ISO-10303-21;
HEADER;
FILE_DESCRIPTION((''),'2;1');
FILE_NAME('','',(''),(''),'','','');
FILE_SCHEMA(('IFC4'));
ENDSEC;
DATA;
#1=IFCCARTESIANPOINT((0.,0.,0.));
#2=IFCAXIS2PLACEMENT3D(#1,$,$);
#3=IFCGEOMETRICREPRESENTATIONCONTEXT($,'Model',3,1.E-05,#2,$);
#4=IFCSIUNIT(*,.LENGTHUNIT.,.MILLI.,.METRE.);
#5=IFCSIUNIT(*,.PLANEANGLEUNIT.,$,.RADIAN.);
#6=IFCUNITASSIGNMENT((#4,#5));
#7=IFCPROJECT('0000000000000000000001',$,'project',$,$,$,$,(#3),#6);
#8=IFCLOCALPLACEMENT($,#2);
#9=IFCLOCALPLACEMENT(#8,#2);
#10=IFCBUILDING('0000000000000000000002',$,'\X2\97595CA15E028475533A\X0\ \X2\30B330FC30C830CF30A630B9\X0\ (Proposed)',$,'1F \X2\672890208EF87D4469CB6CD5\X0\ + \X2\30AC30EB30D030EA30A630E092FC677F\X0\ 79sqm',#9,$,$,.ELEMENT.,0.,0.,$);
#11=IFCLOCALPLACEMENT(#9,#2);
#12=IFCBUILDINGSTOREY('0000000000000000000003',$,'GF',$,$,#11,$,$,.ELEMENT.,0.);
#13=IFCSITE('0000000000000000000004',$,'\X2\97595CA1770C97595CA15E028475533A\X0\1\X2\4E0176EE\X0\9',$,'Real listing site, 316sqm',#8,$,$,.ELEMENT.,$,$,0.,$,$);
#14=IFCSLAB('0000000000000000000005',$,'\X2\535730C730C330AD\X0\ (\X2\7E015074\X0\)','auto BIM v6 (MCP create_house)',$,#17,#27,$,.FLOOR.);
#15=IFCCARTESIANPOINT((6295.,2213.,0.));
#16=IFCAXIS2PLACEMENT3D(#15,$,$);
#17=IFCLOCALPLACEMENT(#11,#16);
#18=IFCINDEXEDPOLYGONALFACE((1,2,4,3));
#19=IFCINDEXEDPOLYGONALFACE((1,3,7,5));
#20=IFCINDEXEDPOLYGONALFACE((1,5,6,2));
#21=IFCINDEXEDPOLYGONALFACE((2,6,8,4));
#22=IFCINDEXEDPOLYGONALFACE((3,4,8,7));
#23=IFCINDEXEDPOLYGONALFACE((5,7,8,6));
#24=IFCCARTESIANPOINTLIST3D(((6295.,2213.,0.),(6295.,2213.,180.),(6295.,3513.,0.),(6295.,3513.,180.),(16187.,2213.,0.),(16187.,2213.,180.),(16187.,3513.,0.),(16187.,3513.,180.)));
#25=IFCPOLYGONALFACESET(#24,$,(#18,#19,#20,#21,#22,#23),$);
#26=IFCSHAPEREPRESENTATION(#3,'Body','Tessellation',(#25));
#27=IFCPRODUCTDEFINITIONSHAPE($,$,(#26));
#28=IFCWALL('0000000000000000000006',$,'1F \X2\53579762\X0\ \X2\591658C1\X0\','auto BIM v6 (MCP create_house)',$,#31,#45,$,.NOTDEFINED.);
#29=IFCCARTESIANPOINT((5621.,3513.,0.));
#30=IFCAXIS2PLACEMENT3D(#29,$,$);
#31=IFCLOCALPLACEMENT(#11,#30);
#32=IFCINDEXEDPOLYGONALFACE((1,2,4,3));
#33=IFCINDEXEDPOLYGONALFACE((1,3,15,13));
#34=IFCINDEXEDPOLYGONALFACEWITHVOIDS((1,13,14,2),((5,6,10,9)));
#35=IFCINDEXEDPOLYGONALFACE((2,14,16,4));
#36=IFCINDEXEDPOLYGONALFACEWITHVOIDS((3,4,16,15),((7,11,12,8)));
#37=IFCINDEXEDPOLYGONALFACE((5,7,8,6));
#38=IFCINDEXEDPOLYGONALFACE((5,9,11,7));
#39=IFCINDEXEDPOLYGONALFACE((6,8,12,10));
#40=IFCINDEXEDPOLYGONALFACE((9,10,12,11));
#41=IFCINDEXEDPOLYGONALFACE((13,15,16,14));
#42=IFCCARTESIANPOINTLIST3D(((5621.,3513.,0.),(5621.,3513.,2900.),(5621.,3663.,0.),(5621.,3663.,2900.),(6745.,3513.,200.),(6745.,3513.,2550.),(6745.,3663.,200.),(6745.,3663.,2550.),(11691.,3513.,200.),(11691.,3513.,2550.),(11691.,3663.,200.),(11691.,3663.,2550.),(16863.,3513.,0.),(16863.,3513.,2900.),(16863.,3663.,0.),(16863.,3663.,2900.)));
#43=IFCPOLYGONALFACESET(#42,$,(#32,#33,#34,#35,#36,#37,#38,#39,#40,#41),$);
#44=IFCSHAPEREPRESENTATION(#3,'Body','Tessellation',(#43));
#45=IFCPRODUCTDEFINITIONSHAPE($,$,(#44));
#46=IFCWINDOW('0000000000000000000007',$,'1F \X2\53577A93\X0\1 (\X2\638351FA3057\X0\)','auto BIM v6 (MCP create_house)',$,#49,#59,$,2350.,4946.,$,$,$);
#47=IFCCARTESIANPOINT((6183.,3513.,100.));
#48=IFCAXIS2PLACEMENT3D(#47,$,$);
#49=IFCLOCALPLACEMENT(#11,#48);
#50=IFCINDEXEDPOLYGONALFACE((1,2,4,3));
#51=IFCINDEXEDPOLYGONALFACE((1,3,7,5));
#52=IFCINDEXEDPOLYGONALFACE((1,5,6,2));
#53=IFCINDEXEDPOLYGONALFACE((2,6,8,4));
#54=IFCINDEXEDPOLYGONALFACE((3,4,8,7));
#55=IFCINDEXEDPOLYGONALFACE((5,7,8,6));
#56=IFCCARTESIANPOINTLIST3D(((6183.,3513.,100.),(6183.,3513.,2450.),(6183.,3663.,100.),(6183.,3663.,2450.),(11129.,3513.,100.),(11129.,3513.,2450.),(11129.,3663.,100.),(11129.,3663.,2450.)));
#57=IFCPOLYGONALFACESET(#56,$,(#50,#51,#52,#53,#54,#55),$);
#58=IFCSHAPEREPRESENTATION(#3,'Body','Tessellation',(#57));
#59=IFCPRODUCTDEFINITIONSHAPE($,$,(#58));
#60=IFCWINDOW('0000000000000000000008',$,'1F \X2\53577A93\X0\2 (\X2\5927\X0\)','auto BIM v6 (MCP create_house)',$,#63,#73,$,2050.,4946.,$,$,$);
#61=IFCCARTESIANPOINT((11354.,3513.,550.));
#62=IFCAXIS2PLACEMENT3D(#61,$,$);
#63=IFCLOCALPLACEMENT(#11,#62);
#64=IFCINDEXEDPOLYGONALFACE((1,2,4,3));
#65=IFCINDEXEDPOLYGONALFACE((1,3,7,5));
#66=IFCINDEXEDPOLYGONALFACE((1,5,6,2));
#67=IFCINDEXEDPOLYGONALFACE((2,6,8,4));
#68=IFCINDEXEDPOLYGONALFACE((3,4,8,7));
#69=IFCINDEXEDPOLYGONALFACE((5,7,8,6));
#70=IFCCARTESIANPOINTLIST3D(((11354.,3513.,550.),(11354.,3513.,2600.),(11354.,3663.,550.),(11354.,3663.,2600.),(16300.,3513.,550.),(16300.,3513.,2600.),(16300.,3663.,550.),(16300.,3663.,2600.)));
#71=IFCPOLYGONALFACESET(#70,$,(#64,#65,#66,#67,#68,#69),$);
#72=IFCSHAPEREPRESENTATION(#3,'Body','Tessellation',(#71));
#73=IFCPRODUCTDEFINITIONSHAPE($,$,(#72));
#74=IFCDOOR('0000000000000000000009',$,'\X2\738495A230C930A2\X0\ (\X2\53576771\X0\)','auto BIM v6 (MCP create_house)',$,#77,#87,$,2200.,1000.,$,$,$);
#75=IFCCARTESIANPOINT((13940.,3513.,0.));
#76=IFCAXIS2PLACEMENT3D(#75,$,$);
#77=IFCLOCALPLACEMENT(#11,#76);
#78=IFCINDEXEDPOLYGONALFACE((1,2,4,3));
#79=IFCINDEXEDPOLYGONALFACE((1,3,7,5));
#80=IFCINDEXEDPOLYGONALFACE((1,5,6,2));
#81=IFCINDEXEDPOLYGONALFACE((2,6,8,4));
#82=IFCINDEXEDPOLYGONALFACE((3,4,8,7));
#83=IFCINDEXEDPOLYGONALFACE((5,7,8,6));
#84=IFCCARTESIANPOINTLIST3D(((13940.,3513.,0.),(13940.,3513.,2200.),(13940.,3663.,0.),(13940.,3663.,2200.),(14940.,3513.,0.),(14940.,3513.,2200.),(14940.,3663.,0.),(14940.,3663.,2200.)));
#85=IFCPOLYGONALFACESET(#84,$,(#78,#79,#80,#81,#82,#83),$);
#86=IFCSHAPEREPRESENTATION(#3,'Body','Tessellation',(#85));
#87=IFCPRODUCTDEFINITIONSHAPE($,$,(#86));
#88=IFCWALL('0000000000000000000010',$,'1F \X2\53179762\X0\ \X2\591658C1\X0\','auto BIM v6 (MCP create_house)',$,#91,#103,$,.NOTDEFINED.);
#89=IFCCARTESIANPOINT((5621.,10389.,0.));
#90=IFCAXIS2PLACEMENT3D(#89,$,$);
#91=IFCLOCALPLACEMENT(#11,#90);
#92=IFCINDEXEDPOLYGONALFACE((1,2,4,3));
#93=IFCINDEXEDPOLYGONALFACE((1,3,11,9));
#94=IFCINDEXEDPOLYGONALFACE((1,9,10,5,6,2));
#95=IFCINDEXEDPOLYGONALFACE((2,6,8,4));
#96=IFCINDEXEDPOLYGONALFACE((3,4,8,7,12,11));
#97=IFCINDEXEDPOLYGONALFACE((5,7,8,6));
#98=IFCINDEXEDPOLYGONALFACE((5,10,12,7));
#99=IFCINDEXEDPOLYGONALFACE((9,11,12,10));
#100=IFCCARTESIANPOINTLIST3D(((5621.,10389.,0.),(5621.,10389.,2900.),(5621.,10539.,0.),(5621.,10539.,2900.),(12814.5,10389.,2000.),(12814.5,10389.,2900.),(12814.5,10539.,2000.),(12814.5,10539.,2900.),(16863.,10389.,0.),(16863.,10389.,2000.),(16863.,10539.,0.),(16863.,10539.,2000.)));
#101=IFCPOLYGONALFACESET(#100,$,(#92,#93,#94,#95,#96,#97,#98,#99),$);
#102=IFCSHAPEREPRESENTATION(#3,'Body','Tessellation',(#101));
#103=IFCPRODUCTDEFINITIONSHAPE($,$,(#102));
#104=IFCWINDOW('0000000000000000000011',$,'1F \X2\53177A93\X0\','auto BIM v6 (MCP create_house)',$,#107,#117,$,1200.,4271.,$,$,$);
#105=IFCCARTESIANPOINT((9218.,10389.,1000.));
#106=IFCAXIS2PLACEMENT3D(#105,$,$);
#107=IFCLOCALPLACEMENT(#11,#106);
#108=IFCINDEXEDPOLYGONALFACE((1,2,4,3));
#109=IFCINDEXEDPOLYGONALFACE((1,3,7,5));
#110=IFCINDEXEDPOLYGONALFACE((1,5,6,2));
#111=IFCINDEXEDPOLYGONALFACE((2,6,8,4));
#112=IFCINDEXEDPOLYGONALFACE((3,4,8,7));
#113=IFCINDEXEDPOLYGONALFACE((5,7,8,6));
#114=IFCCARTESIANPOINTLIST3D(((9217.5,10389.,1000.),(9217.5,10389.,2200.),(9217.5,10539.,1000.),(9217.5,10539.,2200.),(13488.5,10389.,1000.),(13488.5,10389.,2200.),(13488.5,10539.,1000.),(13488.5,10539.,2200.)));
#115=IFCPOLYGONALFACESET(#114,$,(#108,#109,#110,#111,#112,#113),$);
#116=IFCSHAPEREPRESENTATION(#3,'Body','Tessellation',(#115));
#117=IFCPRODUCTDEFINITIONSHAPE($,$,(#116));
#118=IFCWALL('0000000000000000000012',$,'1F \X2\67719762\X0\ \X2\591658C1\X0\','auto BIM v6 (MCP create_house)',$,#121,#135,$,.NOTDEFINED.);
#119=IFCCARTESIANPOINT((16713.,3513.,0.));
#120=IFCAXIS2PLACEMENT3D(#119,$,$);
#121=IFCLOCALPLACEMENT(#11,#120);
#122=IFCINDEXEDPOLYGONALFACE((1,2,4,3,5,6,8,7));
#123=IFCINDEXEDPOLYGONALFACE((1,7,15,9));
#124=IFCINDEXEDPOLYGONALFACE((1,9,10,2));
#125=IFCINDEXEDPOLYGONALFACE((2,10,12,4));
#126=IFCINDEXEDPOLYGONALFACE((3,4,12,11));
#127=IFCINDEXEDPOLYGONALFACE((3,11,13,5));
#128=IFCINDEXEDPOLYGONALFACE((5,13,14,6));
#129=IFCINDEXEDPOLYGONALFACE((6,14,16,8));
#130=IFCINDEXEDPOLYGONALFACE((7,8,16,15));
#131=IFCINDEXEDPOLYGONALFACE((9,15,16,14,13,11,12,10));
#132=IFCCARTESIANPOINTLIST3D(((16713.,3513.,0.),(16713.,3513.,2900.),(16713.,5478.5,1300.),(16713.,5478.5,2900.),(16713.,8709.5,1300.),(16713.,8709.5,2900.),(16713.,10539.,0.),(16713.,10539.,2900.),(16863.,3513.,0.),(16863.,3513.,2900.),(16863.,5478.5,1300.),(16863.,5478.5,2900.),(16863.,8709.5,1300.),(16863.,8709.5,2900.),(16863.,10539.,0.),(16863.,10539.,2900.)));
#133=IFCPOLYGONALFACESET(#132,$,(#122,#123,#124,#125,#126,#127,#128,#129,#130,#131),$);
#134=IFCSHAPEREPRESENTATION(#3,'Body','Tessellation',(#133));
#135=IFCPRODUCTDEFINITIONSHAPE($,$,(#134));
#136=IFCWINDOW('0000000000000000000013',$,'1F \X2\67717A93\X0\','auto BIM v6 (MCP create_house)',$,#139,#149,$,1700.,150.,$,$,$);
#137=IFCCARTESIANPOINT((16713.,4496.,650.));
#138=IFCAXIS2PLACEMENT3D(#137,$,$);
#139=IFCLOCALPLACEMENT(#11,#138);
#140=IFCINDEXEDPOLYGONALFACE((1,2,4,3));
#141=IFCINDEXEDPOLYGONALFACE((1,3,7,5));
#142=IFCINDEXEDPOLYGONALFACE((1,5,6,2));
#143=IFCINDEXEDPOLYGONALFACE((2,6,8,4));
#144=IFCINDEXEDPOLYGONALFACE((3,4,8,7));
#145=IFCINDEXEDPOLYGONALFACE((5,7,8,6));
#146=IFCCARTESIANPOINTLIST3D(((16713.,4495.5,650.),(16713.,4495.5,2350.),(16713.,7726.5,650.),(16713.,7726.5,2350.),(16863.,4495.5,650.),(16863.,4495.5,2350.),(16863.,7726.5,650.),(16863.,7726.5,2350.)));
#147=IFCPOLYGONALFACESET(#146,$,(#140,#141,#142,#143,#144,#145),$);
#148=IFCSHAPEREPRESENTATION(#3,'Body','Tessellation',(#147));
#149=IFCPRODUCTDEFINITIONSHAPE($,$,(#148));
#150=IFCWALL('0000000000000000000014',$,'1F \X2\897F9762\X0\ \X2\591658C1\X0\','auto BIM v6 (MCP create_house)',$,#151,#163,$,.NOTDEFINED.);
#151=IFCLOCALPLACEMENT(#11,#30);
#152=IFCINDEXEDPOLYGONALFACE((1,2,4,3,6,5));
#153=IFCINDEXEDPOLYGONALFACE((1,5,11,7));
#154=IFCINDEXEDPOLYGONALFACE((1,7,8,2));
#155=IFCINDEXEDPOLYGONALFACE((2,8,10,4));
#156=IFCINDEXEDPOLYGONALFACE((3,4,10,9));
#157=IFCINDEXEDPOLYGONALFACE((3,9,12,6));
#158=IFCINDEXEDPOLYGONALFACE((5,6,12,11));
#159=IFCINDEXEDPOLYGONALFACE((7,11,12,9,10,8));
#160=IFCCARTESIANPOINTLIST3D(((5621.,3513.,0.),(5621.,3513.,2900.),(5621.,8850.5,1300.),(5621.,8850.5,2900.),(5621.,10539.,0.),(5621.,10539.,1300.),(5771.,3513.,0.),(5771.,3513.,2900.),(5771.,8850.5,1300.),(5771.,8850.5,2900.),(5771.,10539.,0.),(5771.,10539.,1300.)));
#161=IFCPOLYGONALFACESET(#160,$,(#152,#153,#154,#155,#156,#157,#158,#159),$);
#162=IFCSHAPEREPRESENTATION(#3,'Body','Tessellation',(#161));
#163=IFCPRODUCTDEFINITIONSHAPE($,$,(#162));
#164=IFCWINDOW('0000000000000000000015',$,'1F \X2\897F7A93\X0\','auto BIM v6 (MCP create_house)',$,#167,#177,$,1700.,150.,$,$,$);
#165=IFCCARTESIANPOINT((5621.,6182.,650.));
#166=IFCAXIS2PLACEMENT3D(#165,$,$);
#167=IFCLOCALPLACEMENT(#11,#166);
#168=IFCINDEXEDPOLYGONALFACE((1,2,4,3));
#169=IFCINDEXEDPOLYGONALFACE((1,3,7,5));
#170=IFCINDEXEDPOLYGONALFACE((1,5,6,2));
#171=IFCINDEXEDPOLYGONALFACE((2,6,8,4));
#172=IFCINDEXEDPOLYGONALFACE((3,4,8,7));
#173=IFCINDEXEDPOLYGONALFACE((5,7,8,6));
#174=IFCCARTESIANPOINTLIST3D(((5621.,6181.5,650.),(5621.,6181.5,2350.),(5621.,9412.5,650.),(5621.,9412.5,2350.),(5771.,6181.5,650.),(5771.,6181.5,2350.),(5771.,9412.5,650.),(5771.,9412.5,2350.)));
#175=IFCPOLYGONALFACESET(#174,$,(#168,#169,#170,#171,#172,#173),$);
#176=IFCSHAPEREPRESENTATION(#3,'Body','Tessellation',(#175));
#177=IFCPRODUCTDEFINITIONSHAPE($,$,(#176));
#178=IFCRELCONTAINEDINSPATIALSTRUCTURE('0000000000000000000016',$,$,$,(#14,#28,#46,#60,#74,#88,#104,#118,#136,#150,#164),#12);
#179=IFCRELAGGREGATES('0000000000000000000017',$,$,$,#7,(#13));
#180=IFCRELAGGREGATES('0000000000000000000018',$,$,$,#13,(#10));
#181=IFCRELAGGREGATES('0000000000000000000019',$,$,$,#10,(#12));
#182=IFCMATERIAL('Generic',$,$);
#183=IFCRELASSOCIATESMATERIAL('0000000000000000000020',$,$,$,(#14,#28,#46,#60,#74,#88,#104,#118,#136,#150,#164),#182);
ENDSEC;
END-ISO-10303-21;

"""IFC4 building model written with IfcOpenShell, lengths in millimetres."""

from ifc_helpers import new_model, si_unit, frame, frame_2d, origin, place, context, project, spatial, rectangle, extrude, material, element, fill, save


model = new_model("IFC4")

# Units and contexts
model_context = context("Model", 3, precision=1e-05, world=origin())
ifc_project = project(units=[si_unit("LENGTHUNIT", "METRE", prefix="MILLI"), si_unit("PLANEANGLEUNIT", "RADIAN")], contexts=[model_context])

# Site, building, storey
site_placement = place(None, origin())
site = spatial("IfcSite", under=ifc_project, at=site_placement, Name="静岡県静岡市葵区1丁目9", ObjectType="Real listing site, 316sqm", CompositionType="ELEMENT", RefElevation=0.0)
building_placement = place(site_placement, origin())
building = spatial("IfcBuilding", under=site, at=building_placement, Name="静岡市葵区 コートハウス (Proposed)", ObjectType="1F 木造軸組構法 + ガルバリウム鋼板 79sqm", CompositionType="ELEMENT", ElevationOfRefHeight=0.0, ElevationOfTerrain=0.0)
storey_placement = place(building_placement, origin())
storey = spatial("IfcBuildingStorey", under=building, at=storey_placement, Name="GF", CompositionType="ELEMENT", Elevation=0.0)

# Slab
ifc_material = material(Name="Generic")
slab_1_placement = place(storey_placement, frame((6295.0, 2213.0, 0.0)))
element("IfcSlab", 1, at=slab_1_placement, inside=storey, material=ifc_material, Name="南デッキ (縁側)", Description="auto BIM v6 (MCP create_house)", PredefinedType="FLOOR", context=model_context, shape_type="SweptSolid", body=[
    extrude(rectangle(XDim=9892.0, YDim=1300.0, at=frame_2d((4946.0, 650.0))), frame((6295.0, 2213.0, 0.0)), (0.0, 0.0, 1.0), 180.0),
])

# Wall, openings, windows, door
wall_1_placement = place(storey_placement, frame((5621.0, 3513.0, 0.0)))
wall_1 = element("IfcWall", 2, at=wall_1_placement, inside=storey, material=ifc_material, Name="1F 南面 外壁", Description="auto BIM v6 (MCP create_house)", PredefinedType="NOTDEFINED", context=model_context, shape_type="SweptSolid", body=[
    extrude(rectangle(XDim=11242.0, YDim=150.0, at=frame_2d((5621.0, 75.0))), frame((5621.0, 3513.0, 0.0)), (0.0, 0.0, 1.0), 2900.0),
])
opening_1_placement = place(storey_placement, frame((6183.0, 3513.0, 100.0)))
opening_1 = element("IfcOpeningElement", 3, at=opening_1_placement, cuts=wall_1, PredefinedType="NOTDEFINED", context=model_context, shape_type="SweptSolid", body=[
    extrude(rectangle(XDim=4946.0, YDim=150.0, at=frame_2d((2473.0, 75.0))), frame((6183.0, 3513.0, 100.0)), (0.0, 0.0, 1.0), 2350.0),
])
opening_2_placement = place(storey_placement, frame((11354.0, 3513.0, 550.0)))
opening_2 = element("IfcOpeningElement", 4, at=opening_2_placement, cuts=wall_1, PredefinedType="NOTDEFINED", context=model_context, shape_type="SweptSolid", body=[
    extrude(rectangle(XDim=4946.0, YDim=150.0, at=frame_2d((2473.0, 75.0))), frame((11354.0, 3513.0, 550.0)), (0.0, 0.0, 1.0), 2050.0),
])
opening_3_placement = place(storey_placement, frame((13940.0, 3513.0, 0.0)))
opening_3 = element("IfcOpeningElement", 5, at=opening_3_placement, cuts=wall_1, PredefinedType="NOTDEFINED", context=model_context, shape_type="SweptSolid", body=[
    extrude(rectangle(XDim=1000.0, YDim=150.0, at=frame_2d((500.0, 75.0))), frame((13940.0, 3513.0, 0.0)), (0.0, 0.0, 1.0), 2200.0),
])
window_1_placement = place(storey_placement, frame((6183.0, 3513.0, 100.0)))
window_1 = element("IfcWindow", 6, at=window_1_placement, inside=storey, material=ifc_material, Name="1F 南窓1 (掃出し)", Description="auto BIM v6 (MCP create_house)", OverallHeight=2350.0, OverallWidth=4946.0, context=model_context, shape_type="SweptSolid", body=[
    extrude(rectangle(XDim=4946.0, YDim=150.0, at=frame_2d((2473.0, 75.0))), frame((6183.0, 3513.0, 100.0)), (0.0, 0.0, 1.0), 2350.0),
])
fill(opening_1, window_1)
window_2_placement = place(storey_placement, frame((11354.0, 3513.0, 550.0)))
window_2 = element("IfcWindow", 7, at=window_2_placement, inside=storey, material=ifc_material, Name="1F 南窓2 (大)", Description="auto BIM v6 (MCP create_house)", OverallHeight=2050.0, OverallWidth=4946.0, context=model_context, shape_type="SweptSolid", body=[
    extrude(rectangle(XDim=4946.0, YDim=150.0, at=frame_2d((2473.0, 75.0))), frame((11354.0, 3513.0, 550.0)), (0.0, 0.0, 1.0), 2050.0),
])
fill(opening_2, window_2)
door_placement = place(storey_placement, frame((13940.0, 3513.0, 0.0)))
door = element("IfcDoor", 8, at=door_placement, inside=storey, material=ifc_material, Name="玄関ドア (南東)", Description="auto BIM v6 (MCP create_house)", OverallHeight=2200.0, OverallWidth=1000.0, context=model_context, shape_type="SweptSolid", body=[
    extrude(rectangle(XDim=1000.0, YDim=150.0, at=frame_2d((500.0, 75.0))), frame((13940.0, 3513.0, 0.0)), (0.0, 0.0, 1.0), 2200.0),
])
fill(opening_3, door)

# Walls, openings, windows
wall_2_placement = place(storey_placement, frame((5621.0, 10389.0, 0.0)))
wall_2 = element("IfcWall", 9, at=wall_2_placement, inside=storey, material=ifc_material, Name="1F 北面 外壁", Description="auto BIM v6 (MCP create_house)", PredefinedType="NOTDEFINED", context=model_context, shape_type="SweptSolid", body=[
    extrude(rectangle(XDim=11242.0, YDim=150.0, at=frame_2d((5621.0, 75.0))), frame((5621.0, 10389.0, 0.0)), (0.0, 0.0, 1.0), 2900.0),
])
opening_4_placement = place(storey_placement, frame((9218.0, 10389.0, 1000.0)))
opening_4 = element("IfcOpeningElement", 10, at=opening_4_placement, cuts=wall_2, PredefinedType="NOTDEFINED", context=model_context, shape_type="SweptSolid", body=[
    extrude(rectangle(XDim=4271.0, YDim=150.0, at=frame_2d((2135.0, 75.0))), frame((9218.0, 10389.0, 1000.0)), (0.0, 0.0, 1.0), 1200.0),
])
window_3_placement = place(storey_placement, frame((9218.0, 10389.0, 1000.0)))
window_3 = element("IfcWindow", 11, at=window_3_placement, inside=storey, material=ifc_material, Name="1F 北窓", Description="auto BIM v6 (MCP create_house)", OverallHeight=1200.0, OverallWidth=4271.0, context=model_context, shape_type="SweptSolid", body=[
    extrude(rectangle(XDim=4271.0, YDim=150.0, at=frame_2d((2135.0, 75.0))), frame((9218.0, 10389.0, 1000.0)), (0.0, 0.0, 1.0), 1200.0),
])
fill(opening_4, window_3)
wall_3_placement = place(storey_placement, frame((16713.0, 3513.0, 0.0)))
wall_3 = element("IfcWall", 12, at=wall_3_placement, inside=storey, material=ifc_material, Name="1F 東面 外壁", Description="auto BIM v6 (MCP create_house)", PredefinedType="NOTDEFINED", context=model_context, shape_type="SweptSolid", body=[
    extrude(rectangle(XDim=150.0, YDim=7026.0, at=frame_2d((75.0, 3513.0))), frame((16713.0, 3513.0, 0.0)), (0.0, 0.0, 1.0), 2900.0),
])
opening_5_placement = place(storey_placement, frame((16713.0, 4496.0, 650.0)))
opening_5 = element("IfcOpeningElement", 13, at=opening_5_placement, cuts=wall_3, PredefinedType="NOTDEFINED", context=model_context, shape_type="SweptSolid", body=[
    extrude(rectangle(XDim=150.0, YDim=3231.0, at=frame_2d((75.0, 1615.0))), frame((16713.0, 4496.0, 650.0)), (0.0, 0.0, 1.0), 1700.0),
])
window_4_placement = place(storey_placement, frame((16713.0, 4496.0, 650.0)))
window_4 = element("IfcWindow", 14, at=window_4_placement, inside=storey, material=ifc_material, Name="1F 東窓", Description="auto BIM v6 (MCP create_house)", OverallHeight=1700.0, OverallWidth=150.0, context=model_context, shape_type="SweptSolid", body=[
    extrude(rectangle(XDim=150.0, YDim=3231.0, at=frame_2d((75.0, 1615.0))), frame((16713.0, 4496.0, 650.0)), (0.0, 0.0, 1.0), 1700.0),
])
fill(opening_5, window_4)
wall_4_placement = place(storey_placement, frame((5621.0, 3513.0, 0.0)))
wall_4 = element("IfcWall", 15, at=wall_4_placement, inside=storey, material=ifc_material, Name="1F 西面 外壁", Description="auto BIM v6 (MCP create_house)", PredefinedType="NOTDEFINED", context=model_context, shape_type="SweptSolid", body=[
    extrude(rectangle(XDim=150.0, YDim=7026.0, at=frame_2d((75.0, 3513.0))), frame((5621.0, 3513.0, 0.0)), (0.0, 0.0, 1.0), 2900.0),
])
opening_6_placement = place(storey_placement, frame((5621.0, 6182.0, 650.0)))
opening_6 = element("IfcOpeningElement", 16, at=opening_6_placement, cuts=wall_4, PredefinedType="NOTDEFINED", context=model_context, shape_type="SweptSolid", body=[
    extrude(rectangle(XDim=150.0, YDim=3231.0, at=frame_2d((75.0, 1615.0))), frame((5621.0, 6182.0, 650.0)), (0.0, 0.0, 1.0), 1700.0),
])
window_5_placement = place(storey_placement, frame((5621.0, 6182.0, 650.0)))
window_5 = element("IfcWindow", 17, at=window_5_placement, inside=storey, material=ifc_material, Name="1F 西窓", Description="auto BIM v6 (MCP create_house)", OverallHeight=1700.0, OverallWidth=150.0, context=model_context, shape_type="SweptSolid", body=[
    extrude(rectangle(XDim=150.0, YDim=3231.0, at=frame_2d((75.0, 1615.0))), frame((5621.0, 6182.0, 650.0)), (0.0, 0.0, 1.0), 1700.0),
])
fill(opening_6, window_5)

save(model, "model.ifc")
